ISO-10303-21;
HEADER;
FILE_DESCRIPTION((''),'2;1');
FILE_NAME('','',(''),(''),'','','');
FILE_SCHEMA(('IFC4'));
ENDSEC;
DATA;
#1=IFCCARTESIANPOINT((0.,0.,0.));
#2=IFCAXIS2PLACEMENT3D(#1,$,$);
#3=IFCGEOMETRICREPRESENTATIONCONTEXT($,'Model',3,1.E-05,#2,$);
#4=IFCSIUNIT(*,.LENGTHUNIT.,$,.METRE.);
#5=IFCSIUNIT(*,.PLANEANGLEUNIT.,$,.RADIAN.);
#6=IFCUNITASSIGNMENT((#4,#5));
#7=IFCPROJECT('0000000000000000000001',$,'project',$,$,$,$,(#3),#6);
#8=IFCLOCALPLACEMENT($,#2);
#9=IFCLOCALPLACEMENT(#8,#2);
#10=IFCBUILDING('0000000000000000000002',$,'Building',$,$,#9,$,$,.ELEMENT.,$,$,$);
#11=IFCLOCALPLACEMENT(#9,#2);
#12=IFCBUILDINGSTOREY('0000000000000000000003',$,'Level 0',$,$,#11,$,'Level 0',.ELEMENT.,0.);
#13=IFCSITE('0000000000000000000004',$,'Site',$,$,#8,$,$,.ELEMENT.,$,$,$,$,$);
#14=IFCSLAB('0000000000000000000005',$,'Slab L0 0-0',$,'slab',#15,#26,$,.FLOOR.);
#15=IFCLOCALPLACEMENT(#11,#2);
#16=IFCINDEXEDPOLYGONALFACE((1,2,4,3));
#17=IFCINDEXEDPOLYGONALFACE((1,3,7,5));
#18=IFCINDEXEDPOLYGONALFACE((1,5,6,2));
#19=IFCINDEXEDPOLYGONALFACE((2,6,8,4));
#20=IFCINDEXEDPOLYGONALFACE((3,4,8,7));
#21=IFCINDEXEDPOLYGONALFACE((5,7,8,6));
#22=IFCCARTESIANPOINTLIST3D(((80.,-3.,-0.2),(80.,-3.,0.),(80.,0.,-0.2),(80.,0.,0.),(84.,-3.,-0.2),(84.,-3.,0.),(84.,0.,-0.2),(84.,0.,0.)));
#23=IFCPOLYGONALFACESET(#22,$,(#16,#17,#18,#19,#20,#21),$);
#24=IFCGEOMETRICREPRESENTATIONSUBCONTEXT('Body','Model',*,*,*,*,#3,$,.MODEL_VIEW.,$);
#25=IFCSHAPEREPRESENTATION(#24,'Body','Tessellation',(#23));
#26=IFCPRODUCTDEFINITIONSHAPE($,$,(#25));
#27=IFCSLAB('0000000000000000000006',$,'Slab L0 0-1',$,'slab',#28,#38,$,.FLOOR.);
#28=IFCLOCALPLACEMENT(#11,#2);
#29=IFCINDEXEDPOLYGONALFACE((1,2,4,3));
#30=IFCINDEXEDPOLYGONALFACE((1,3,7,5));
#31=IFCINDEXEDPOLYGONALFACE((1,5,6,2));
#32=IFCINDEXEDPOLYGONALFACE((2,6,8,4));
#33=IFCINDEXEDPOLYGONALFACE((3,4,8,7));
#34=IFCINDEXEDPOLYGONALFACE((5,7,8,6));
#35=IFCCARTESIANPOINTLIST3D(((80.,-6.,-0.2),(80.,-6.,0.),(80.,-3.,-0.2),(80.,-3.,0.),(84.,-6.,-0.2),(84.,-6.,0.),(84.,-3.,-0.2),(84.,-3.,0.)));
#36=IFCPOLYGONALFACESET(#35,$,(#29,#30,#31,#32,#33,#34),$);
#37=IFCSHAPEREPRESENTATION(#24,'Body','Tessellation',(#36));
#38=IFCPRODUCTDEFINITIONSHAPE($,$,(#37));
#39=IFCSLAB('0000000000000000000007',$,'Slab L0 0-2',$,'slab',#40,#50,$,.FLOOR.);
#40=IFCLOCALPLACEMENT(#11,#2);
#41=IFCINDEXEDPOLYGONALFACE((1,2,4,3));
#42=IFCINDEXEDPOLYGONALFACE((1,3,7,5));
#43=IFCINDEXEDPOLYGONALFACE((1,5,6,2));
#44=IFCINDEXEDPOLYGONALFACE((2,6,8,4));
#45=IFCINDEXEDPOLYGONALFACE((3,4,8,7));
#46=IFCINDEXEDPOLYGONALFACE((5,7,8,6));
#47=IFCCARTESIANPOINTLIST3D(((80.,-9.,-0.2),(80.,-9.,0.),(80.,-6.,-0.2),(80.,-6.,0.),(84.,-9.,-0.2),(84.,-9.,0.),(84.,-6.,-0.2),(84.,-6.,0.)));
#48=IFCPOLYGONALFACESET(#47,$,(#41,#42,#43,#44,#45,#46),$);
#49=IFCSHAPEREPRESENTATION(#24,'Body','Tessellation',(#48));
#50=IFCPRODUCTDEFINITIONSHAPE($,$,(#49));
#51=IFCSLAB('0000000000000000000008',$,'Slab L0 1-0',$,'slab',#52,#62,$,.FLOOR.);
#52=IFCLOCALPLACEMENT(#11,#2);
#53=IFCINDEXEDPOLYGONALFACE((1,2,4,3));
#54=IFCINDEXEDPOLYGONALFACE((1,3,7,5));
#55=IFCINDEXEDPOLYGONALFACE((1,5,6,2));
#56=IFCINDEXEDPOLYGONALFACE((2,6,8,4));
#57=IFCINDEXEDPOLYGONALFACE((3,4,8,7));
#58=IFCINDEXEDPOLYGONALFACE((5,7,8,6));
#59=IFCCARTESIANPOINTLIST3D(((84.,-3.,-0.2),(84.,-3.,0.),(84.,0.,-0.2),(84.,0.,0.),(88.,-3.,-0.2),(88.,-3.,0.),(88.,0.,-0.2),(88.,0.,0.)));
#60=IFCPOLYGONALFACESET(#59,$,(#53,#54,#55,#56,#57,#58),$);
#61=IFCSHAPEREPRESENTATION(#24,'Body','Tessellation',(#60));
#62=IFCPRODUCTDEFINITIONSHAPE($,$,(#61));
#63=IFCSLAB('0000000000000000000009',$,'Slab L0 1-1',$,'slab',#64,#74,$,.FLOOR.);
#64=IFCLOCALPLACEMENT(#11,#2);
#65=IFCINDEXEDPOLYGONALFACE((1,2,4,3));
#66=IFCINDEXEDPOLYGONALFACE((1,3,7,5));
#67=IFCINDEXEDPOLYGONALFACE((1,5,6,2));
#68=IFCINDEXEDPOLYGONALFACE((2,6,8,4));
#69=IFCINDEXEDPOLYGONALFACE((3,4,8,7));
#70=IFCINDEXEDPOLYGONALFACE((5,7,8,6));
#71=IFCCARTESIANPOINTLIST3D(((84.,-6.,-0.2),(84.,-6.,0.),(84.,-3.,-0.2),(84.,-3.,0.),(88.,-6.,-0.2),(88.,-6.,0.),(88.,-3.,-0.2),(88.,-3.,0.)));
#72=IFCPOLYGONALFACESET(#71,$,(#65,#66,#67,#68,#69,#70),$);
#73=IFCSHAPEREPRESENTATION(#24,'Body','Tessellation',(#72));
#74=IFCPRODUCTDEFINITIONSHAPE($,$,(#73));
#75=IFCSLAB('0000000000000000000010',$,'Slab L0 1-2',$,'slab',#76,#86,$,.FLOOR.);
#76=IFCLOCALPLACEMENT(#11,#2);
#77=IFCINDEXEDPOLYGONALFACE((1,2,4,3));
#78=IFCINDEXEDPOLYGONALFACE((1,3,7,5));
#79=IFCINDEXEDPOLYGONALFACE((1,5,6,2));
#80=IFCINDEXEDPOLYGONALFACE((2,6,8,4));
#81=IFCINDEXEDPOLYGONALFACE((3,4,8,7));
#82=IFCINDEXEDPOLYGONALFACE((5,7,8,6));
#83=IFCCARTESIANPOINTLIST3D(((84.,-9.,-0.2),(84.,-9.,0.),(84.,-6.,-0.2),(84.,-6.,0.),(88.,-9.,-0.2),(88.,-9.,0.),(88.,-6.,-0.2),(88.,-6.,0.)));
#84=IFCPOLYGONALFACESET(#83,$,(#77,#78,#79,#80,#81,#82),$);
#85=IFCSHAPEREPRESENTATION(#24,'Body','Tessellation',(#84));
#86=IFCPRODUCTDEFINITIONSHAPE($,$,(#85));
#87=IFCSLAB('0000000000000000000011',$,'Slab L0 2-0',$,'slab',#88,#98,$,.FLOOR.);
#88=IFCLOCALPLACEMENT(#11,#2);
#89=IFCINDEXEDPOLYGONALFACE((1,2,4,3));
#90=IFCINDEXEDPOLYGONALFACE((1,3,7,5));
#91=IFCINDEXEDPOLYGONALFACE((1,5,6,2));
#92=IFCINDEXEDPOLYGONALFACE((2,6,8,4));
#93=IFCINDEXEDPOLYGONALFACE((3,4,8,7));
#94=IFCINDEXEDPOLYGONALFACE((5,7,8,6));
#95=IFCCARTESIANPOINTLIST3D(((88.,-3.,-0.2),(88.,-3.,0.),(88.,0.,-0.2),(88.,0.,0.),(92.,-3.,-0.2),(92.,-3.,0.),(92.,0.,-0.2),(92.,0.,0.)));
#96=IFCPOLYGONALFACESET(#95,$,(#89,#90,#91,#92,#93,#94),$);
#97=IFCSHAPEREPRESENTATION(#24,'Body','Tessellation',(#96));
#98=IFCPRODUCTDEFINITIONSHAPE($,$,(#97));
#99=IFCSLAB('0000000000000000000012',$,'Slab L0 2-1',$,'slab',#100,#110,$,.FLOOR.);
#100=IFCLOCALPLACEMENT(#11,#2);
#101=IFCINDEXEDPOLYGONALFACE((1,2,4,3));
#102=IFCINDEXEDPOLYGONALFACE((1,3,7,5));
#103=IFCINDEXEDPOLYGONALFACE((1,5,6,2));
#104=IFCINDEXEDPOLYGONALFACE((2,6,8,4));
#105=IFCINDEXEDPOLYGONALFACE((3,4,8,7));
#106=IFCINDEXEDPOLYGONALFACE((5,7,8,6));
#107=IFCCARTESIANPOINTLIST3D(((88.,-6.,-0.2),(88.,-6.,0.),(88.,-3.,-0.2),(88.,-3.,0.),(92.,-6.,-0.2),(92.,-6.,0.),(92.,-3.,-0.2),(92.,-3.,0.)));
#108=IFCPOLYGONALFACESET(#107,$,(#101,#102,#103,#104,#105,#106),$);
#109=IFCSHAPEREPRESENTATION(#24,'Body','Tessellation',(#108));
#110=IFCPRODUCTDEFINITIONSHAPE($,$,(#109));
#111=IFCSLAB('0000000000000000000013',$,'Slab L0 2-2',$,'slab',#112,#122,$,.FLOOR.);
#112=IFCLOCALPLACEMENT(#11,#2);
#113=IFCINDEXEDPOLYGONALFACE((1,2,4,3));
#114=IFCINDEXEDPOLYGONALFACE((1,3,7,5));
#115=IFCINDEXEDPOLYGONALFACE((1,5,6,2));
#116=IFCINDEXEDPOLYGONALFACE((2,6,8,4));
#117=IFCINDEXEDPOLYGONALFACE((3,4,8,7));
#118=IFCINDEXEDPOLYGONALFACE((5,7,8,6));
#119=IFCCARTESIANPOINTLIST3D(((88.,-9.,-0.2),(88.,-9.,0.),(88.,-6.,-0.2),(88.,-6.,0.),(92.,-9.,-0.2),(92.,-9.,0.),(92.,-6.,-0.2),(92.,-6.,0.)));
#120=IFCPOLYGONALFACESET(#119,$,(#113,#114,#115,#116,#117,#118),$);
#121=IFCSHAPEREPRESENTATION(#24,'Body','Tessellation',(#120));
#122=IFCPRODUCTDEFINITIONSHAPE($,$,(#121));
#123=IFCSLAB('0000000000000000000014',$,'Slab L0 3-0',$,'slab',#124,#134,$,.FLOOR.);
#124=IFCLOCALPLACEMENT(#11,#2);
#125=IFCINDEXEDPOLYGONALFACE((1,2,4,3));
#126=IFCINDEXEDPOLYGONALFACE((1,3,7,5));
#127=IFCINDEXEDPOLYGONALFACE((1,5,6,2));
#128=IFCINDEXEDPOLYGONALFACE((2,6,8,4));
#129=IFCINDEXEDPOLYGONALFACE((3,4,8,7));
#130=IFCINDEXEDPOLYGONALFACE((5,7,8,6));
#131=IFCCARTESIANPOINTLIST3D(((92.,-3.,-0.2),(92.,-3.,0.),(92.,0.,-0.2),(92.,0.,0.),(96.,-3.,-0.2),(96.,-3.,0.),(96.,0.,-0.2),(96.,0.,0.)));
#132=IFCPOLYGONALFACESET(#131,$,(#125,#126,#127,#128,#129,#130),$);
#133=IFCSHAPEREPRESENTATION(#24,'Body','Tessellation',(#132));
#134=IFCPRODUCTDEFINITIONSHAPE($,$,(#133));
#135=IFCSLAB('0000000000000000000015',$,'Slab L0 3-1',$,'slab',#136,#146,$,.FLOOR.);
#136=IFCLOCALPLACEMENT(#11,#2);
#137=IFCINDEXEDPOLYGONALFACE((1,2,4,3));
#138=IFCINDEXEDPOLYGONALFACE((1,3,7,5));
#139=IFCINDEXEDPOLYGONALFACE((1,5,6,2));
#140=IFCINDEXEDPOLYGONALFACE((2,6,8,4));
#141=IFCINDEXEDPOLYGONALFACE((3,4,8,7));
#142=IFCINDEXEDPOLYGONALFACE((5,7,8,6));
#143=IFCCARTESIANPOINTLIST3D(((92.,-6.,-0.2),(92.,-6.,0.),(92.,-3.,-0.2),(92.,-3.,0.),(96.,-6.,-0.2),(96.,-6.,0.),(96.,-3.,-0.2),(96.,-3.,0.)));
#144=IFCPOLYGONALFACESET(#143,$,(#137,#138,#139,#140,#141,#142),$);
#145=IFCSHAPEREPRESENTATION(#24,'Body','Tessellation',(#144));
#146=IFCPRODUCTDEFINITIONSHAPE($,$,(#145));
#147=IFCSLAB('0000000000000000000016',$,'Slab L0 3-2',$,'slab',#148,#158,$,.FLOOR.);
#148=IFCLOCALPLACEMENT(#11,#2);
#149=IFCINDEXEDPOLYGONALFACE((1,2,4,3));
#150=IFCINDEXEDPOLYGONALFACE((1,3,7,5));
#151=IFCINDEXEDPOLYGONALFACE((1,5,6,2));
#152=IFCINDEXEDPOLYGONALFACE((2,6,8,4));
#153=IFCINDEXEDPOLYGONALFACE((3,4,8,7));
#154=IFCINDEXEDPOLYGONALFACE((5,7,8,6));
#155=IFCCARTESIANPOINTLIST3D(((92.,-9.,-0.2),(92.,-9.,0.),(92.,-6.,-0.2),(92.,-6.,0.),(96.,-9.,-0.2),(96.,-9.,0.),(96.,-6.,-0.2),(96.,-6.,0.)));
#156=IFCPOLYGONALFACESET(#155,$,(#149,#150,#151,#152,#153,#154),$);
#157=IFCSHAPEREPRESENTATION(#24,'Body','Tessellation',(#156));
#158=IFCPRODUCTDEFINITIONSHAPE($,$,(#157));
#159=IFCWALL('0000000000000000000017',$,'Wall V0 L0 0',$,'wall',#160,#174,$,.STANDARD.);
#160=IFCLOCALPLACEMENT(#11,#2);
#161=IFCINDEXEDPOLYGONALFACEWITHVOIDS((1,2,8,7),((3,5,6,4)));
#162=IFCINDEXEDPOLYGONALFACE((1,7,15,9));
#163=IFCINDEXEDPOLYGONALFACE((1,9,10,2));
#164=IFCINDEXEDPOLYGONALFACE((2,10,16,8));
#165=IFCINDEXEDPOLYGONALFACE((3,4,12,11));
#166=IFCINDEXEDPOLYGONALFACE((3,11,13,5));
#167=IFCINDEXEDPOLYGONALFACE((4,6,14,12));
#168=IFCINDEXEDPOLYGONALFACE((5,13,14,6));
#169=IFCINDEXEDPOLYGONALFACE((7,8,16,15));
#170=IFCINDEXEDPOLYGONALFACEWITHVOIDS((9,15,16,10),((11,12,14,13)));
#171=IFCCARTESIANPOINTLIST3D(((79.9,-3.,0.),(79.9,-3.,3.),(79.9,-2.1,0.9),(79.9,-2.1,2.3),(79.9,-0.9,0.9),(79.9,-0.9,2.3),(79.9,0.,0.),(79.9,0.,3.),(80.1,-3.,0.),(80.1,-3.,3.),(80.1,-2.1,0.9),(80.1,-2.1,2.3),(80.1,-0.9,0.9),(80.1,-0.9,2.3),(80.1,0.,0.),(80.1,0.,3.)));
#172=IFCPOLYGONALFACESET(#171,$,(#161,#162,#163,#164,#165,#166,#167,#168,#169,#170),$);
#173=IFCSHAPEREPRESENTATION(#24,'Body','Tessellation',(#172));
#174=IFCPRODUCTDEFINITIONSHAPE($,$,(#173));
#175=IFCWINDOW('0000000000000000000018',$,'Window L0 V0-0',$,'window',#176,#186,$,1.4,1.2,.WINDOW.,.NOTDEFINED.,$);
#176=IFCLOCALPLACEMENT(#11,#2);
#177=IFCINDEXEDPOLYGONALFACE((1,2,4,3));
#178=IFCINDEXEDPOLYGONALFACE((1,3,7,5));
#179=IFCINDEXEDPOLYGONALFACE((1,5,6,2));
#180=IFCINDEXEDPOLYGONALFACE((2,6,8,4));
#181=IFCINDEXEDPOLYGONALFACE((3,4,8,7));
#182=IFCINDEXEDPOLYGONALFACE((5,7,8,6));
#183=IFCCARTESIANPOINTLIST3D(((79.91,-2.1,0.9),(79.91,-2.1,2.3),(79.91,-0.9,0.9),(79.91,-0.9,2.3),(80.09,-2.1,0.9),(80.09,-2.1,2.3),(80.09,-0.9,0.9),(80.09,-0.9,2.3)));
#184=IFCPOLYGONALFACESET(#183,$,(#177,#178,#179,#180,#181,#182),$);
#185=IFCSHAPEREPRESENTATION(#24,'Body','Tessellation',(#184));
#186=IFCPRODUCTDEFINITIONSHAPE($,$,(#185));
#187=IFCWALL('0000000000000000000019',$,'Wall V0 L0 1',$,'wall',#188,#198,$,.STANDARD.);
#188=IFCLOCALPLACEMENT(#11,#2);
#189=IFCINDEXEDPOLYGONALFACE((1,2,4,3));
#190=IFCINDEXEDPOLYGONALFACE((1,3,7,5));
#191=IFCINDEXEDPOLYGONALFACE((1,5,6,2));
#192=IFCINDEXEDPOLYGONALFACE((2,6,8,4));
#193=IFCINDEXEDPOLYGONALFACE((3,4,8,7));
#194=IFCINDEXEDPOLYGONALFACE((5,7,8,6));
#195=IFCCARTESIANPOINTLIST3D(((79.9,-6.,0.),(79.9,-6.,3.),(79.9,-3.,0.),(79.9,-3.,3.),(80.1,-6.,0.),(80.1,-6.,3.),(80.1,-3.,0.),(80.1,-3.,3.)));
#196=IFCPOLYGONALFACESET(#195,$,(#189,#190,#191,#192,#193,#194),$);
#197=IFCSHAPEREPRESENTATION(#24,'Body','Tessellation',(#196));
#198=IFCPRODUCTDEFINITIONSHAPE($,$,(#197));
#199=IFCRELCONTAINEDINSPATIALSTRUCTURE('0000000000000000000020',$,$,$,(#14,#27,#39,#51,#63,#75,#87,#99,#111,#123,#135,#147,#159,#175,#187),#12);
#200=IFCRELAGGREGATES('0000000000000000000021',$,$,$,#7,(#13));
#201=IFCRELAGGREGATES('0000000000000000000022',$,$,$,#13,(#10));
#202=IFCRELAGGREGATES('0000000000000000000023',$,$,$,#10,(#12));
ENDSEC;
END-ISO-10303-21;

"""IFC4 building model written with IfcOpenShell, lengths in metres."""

from ifc_helpers import new_model, si_unit, frame, frame_2d, origin, origin_2d, place, context, subcontext, project, spatial, polyline, rectangle, outline, extrude, element, fill, save


model = new_model("IFC4")

# Units and contexts
model_context = context("Model", 3, precision=1e-05, world=origin())
body_context = subcontext(model_context, "Body", "Model", "MODEL_VIEW")
ifc_project = project(units=[si_unit("LENGTHUNIT", "METRE"), si_unit("PLANEANGLEUNIT", "RADIAN")], contexts=[model_context])

# Site, building, storey
site_placement = place(None, origin())
site = spatial("IfcSite", under=ifc_project, at=site_placement, Name="Site", CompositionType="ELEMENT")
building_placement = place(site_placement, origin())
building = spatial("IfcBuilding", under=site, at=building_placement, Name="Building", CompositionType="ELEMENT")
storey_placement = place(building_placement, origin())
storey = spatial("IfcBuildingStorey", under=building, at=storey_placement, Name="Level 0", LongName="Level 0", CompositionType="ELEMENT", Elevation=0.0)

# Slabs
slab_1_placement = place(storey_placement, frame((0.0, 0.0, -0.2)))
element("IfcSlab", 1, at=slab_1_placement, inside=storey, Name="Slab L0 0-0", ObjectType="slab", PredefinedType="FLOOR", context=body_context, shape_type="SweptSolid", body=[
    extrude(outline(polyline([(80.0, -3.0), (84.0, -3.0), (84.0, 0.0), (80.0, 0.0), (80.0, -3.0)])), origin(), (0.0, 0.0, 1.0), 0.2),
])
slab_2_placement = place(storey_placement, frame((0.0, 0.0, -0.2)))
element("IfcSlab", 2, at=slab_2_placement, inside=storey, Name="Slab L0 0-1", ObjectType="slab", PredefinedType="FLOOR", context=body_context, shape_type="SweptSolid", body=[
    extrude(outline(polyline([(80.0, -6.0), (84.0, -6.0), (84.0, -3.0), (80.0, -3.0), (80.0, -6.0)])), origin(), (0.0, 0.0, 1.0), 0.2),
])
slab_3_placement = place(storey_placement, frame((0.0, 0.0, -0.2)))
element("IfcSlab", 3, at=slab_3_placement, inside=storey, Name="Slab L0 0-2", ObjectType="slab", PredefinedType="FLOOR", context=body_context, shape_type="SweptSolid", body=[
    extrude(outline(polyline([(80.0, -9.0), (84.0, -9.0), (84.0, -6.0), (80.0, -6.0), (80.0, -9.0)])), origin(), (0.0, 0.0, 1.0), 0.2),
])
slab_4_placement = place(storey_placement, frame((0.0, 0.0, -0.2)))
element("IfcSlab", 4, at=slab_4_placement, inside=storey, Name="Slab L0 1-0", ObjectType="slab", PredefinedType="FLOOR", context=body_context, shape_type="SweptSolid", body=[
    extrude(outline(polyline([(84.0, -3.0), (88.0, -3.0), (88.0, 0.0), (84.0, 0.0), (84.0, -3.0)])), origin(), (0.0, 0.0, 1.0), 0.2),
])
slab_5_placement = place(storey_placement, frame((0.0, 0.0, -0.2)))
element("IfcSlab", 5, at=slab_5_placement, inside=storey, Name="Slab L0 1-1", ObjectType="slab", PredefinedType="FLOOR", context=body_context, shape_type="SweptSolid", body=[
    extrude(outline(polyline([(84.0, -6.0), (88.0, -6.0), (88.0, -3.0), (84.0, -3.0), (84.0, -6.0)])), origin(), (0.0, 0.0, 1.0), 0.2),
])
slab_6_placement = place(storey_placement, frame((0.0, 0.0, -0.2)))
element("IfcSlab", 6, at=slab_6_placement, inside=storey, Name="Slab L0 1-2", ObjectType="slab", PredefinedType="FLOOR", context=body_context, shape_type="SweptSolid", body=[
    extrude(outline(polyline([(84.0, -9.0), (88.0, -9.0), (88.0, -6.0), (84.0, -6.0), (84.0, -9.0)])), origin(), (0.0, 0.0, 1.0), 0.2),
])
slab_7_placement = place(storey_placement, frame((0.0, 0.0, -0.2)))
element("IfcSlab", 7, at=slab_7_placement, inside=storey, Name="Slab L0 2-0", ObjectType="slab", PredefinedType="FLOOR", context=body_context, shape_type="SweptSolid", body=[
    extrude(outline(polyline([(88.0, -3.0), (92.0, -3.0), (92.0, 0.0), (88.0, 0.0), (88.0, -3.0)])), origin(), (0.0, 0.0, 1.0), 0.2),
])
slab_8_placement = place(storey_placement, frame((0.0, 0.0, -0.2)))
element("IfcSlab", 8, at=slab_8_placement, inside=storey, Name="Slab L0 2-1", ObjectType="slab", PredefinedType="FLOOR", context=body_context, shape_type="SweptSolid", body=[
    extrude(outline(polyline([(88.0, -6.0), (92.0, -6.0), (92.0, -3.0), (88.0, -3.0), (88.0, -6.0)])), origin(), (0.0, 0.0, 1.0), 0.2),
])
slab_9_placement = place(storey_placement, frame((0.0, 0.0, -0.2)))
element("IfcSlab", 9, at=slab_9_placement, inside=storey, Name="Slab L0 2-2", ObjectType="slab", PredefinedType="FLOOR", context=body_context, shape_type="SweptSolid", body=[
    extrude(outline(polyline([(88.0, -9.0), (92.0, -9.0), (92.0, -6.0), (88.0, -6.0), (88.0, -9.0)])), origin(), (0.0, 0.0, 1.0), 0.2),
])
slab_10_placement = place(storey_placement, frame((0.0, 0.0, -0.2)))
element("IfcSlab", 10, at=slab_10_placement, inside=storey, Name="Slab L0 3-0", ObjectType="slab", PredefinedType="FLOOR", context=body_context, shape_type="SweptSolid", body=[
    extrude(outline(polyline([(92.0, -3.0), (96.0, -3.0), (96.0, 0.0), (92.0, 0.0), (92.0, -3.0)])), origin(), (0.0, 0.0, 1.0), 0.2),
])
slab_11_placement = place(storey_placement, frame((0.0, 0.0, -0.2)))
element("IfcSlab", 11, at=slab_11_placement, inside=storey, Name="Slab L0 3-1", ObjectType="slab", PredefinedType="FLOOR", context=body_context, shape_type="SweptSolid", body=[
    extrude(outline(polyline([(92.0, -6.0), (96.0, -6.0), (96.0, -3.0), (92.0, -3.0), (92.0, -6.0)])), origin(), (0.0, 0.0, 1.0), 0.2),
])
slab_12_placement = place(storey_placement, frame((0.0, 0.0, -0.2)))
element("IfcSlab", 12, at=slab_12_placement, inside=storey, Name="Slab L0 3-2", ObjectType="slab", PredefinedType="FLOOR", context=body_context, shape_type="SweptSolid", body=[
    extrude(outline(polyline([(92.0, -9.0), (96.0, -9.0), (96.0, -6.0), (92.0, -6.0), (92.0, -9.0)])), origin(), (0.0, 0.0, 1.0), 0.2),
])

# Wall, opening, window
wall_1_placement = place(storey_placement, frame((80.0, 0.0, 0.0), z_axis=(0.0, 0.0, 1.0), x_axis=(0.0, -1.0, 0.0)))
wall_1 = element("IfcWall", 13, at=wall_1_placement, inside=storey, Name="Wall V0 L0 0", ObjectType="wall", PredefinedType="STANDARD", context=body_context, shape_type="SweptSolid", body=[
    extrude(rectangle(XDim=3.0, YDim=0.2, at=frame_2d((1.5, 0.0))), origin(), (0.0, 0.0, 1.0), 3.0),
])
opening_1_placement = place(storey_placement, frame((80.0, -1.5, 0.9), z_axis=(0.0, 0.0, 1.0), x_axis=(0.0, -1.0, 0.0)))
opening_1 = element("IfcOpeningElement", 14, at=opening_1_placement, cuts=wall_1, ObjectType="Opening", PredefinedType="OPENING", context=body_context, shape_type="SweptSolid", body=[
    extrude(rectangle(XDim=1.2, YDim=0.22, at=origin_2d()), origin(), (0.0, 0.0, 1.0), 1.4),
])
window_1_placement = place(storey_placement, frame((80.0, -1.5, 0.9), z_axis=(0.0, 0.0, 1.0), x_axis=(0.0, -1.0, 0.0)))
window_1 = element("IfcWindow", 15, at=window_1_placement, inside=storey, Name="Window L0 V0-0", ObjectType="window", OverallHeight=1.4, OverallWidth=1.2, PartitioningType="NOTDEFINED", PredefinedType="WINDOW", context=body_context, shape_type="SweptSolid", body=[
    extrude(rectangle(XDim=1.2, YDim=0.18, at=origin_2d()), origin(), (0.0, 0.0, 1.0), 1.4),
])
fill(opening_1, window_1)

# Wall
wall_2_placement = place(storey_placement, frame((80.0, -3.0, 0.0), z_axis=(0.0, 0.0, 1.0), x_axis=(0.0, -1.0, 0.0)))
element("IfcWall", 16, at=wall_2_placement, inside=storey, Name="Wall V0 L0 1", ObjectType="wall", PredefinedType="STANDARD", context=body_context, shape_type="SweptSolid", body=[
    extrude(rectangle(XDim=3.0, YDim=0.2, at=frame_2d((1.5, 0.0))), origin(), (0.0, 0.0, 1.0), 3.0),
])

save(model, "model.ifc")
